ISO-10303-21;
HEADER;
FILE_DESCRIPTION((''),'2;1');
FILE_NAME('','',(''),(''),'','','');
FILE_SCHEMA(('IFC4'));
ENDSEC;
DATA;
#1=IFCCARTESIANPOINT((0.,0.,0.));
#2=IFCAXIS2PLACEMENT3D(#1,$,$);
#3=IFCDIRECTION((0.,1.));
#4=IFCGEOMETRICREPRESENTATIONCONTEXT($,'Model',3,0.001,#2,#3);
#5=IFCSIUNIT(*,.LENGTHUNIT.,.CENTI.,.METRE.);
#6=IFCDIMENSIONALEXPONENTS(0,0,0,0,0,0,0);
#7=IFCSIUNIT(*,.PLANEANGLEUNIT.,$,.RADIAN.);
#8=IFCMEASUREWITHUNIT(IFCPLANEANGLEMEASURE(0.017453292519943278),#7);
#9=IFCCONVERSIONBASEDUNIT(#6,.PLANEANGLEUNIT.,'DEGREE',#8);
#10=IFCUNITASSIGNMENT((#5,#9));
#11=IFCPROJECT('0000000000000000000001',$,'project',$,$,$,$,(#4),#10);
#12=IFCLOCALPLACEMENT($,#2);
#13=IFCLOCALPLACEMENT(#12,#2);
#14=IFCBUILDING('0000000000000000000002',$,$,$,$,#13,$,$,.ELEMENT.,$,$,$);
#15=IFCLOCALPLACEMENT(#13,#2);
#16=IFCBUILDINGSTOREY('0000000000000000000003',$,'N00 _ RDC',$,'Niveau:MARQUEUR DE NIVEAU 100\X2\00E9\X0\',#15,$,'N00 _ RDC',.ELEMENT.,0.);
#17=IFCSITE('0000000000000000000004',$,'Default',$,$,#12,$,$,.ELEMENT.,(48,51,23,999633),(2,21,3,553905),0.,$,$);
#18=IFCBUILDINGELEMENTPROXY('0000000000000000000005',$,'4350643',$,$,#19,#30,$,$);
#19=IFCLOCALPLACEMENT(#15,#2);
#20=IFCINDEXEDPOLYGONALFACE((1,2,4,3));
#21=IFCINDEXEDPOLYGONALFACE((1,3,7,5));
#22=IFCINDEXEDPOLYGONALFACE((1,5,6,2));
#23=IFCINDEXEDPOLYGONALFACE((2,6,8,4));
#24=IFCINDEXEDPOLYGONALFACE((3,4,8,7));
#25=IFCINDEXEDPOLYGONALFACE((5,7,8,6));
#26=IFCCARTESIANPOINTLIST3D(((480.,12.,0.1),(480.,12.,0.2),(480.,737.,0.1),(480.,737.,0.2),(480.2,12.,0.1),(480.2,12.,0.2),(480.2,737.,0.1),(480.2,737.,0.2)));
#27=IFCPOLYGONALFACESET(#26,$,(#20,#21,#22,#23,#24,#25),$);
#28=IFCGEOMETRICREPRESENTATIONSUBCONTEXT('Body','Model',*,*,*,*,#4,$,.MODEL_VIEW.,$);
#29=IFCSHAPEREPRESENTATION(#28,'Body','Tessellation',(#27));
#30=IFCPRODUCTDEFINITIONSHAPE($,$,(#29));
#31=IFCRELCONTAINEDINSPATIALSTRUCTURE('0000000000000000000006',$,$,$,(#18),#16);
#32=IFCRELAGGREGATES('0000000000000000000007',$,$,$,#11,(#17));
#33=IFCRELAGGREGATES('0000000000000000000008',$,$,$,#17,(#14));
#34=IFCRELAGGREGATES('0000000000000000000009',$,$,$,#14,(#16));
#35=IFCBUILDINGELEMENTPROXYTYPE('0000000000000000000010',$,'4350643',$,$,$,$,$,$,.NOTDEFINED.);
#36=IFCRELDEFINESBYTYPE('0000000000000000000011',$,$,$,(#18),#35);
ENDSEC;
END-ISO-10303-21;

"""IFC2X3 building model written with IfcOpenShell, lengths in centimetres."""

from ifc_helpers import new_model, entity, si_unit, converted_unit, direction, frame, origin, origin_2d_with_axis, place, context, subcontext, project, spatial, rectangle, extrude, type_object, element, save


model = new_model("IFC2X3")

# Units and contexts
model_context = context("Model", 3, precision=0.001, world=origin(), true_north=direction((0.0, 1.0)))
body_context = subcontext(model_context, "Body", "Model", "MODEL_VIEW")
ifc_project = project(units=[si_unit("LENGTHUNIT", "METRE", prefix="CENTI"), converted_unit("PLANEANGLEUNIT", "DEGREE", entity("IfcPlaneAngleMeasure", 0.017453292519943278), si_unit("PLANEANGLEUNIT", "RADIAN"), dimensions=[0, 0, 0, 0, 0, 0, 0])], contexts=[model_context])

# Site, building, storey
site_placement = place(None, origin())
site = spatial("IfcSite", under=ifc_project, at=site_placement, Name="Default", CompositionType="ELEMENT", RefLatitude=(48, 51, 23, 999633), RefLongitude=(2, 21, 3, 553905), RefElevation=0.0)
building_placement = place(site_placement, origin())
building = spatial("IfcBuilding", under=site, at=building_placement, CompositionType="ELEMENT")
storey_placement = place(building_placement, origin())
storey = spatial("IfcBuildingStorey", under=building, at=storey_placement, Name="N00 _ RDC", ObjectType="Niveau:MARQUEUR DE NIVEAU 100é", LongName="N00 _ RDC", CompositionType="ELEMENT", Elevation=0.0)

# Building element proxy
building_element_proxy_type_1 = type_object("IfcBuildingElementProxyType", Name="4350643", PredefinedType="NOTDEFINED")
proxy_1_placement = place(storey_placement, origin())
element("IfcBuildingElementProxy", 1, at=proxy_1_placement, inside=storey, type_object=building_element_proxy_type_1, Name="4350643", context=body_context, shape_type="SweptSolid", body=[
    extrude(rectangle(XDim=0.2, YDim=725.0, at=origin_2d_with_axis()), frame((480.1, 374.5, 0.1)), (0.0, 0.0, 1.0), 0.1),
])

save(model, "model.ifc")
